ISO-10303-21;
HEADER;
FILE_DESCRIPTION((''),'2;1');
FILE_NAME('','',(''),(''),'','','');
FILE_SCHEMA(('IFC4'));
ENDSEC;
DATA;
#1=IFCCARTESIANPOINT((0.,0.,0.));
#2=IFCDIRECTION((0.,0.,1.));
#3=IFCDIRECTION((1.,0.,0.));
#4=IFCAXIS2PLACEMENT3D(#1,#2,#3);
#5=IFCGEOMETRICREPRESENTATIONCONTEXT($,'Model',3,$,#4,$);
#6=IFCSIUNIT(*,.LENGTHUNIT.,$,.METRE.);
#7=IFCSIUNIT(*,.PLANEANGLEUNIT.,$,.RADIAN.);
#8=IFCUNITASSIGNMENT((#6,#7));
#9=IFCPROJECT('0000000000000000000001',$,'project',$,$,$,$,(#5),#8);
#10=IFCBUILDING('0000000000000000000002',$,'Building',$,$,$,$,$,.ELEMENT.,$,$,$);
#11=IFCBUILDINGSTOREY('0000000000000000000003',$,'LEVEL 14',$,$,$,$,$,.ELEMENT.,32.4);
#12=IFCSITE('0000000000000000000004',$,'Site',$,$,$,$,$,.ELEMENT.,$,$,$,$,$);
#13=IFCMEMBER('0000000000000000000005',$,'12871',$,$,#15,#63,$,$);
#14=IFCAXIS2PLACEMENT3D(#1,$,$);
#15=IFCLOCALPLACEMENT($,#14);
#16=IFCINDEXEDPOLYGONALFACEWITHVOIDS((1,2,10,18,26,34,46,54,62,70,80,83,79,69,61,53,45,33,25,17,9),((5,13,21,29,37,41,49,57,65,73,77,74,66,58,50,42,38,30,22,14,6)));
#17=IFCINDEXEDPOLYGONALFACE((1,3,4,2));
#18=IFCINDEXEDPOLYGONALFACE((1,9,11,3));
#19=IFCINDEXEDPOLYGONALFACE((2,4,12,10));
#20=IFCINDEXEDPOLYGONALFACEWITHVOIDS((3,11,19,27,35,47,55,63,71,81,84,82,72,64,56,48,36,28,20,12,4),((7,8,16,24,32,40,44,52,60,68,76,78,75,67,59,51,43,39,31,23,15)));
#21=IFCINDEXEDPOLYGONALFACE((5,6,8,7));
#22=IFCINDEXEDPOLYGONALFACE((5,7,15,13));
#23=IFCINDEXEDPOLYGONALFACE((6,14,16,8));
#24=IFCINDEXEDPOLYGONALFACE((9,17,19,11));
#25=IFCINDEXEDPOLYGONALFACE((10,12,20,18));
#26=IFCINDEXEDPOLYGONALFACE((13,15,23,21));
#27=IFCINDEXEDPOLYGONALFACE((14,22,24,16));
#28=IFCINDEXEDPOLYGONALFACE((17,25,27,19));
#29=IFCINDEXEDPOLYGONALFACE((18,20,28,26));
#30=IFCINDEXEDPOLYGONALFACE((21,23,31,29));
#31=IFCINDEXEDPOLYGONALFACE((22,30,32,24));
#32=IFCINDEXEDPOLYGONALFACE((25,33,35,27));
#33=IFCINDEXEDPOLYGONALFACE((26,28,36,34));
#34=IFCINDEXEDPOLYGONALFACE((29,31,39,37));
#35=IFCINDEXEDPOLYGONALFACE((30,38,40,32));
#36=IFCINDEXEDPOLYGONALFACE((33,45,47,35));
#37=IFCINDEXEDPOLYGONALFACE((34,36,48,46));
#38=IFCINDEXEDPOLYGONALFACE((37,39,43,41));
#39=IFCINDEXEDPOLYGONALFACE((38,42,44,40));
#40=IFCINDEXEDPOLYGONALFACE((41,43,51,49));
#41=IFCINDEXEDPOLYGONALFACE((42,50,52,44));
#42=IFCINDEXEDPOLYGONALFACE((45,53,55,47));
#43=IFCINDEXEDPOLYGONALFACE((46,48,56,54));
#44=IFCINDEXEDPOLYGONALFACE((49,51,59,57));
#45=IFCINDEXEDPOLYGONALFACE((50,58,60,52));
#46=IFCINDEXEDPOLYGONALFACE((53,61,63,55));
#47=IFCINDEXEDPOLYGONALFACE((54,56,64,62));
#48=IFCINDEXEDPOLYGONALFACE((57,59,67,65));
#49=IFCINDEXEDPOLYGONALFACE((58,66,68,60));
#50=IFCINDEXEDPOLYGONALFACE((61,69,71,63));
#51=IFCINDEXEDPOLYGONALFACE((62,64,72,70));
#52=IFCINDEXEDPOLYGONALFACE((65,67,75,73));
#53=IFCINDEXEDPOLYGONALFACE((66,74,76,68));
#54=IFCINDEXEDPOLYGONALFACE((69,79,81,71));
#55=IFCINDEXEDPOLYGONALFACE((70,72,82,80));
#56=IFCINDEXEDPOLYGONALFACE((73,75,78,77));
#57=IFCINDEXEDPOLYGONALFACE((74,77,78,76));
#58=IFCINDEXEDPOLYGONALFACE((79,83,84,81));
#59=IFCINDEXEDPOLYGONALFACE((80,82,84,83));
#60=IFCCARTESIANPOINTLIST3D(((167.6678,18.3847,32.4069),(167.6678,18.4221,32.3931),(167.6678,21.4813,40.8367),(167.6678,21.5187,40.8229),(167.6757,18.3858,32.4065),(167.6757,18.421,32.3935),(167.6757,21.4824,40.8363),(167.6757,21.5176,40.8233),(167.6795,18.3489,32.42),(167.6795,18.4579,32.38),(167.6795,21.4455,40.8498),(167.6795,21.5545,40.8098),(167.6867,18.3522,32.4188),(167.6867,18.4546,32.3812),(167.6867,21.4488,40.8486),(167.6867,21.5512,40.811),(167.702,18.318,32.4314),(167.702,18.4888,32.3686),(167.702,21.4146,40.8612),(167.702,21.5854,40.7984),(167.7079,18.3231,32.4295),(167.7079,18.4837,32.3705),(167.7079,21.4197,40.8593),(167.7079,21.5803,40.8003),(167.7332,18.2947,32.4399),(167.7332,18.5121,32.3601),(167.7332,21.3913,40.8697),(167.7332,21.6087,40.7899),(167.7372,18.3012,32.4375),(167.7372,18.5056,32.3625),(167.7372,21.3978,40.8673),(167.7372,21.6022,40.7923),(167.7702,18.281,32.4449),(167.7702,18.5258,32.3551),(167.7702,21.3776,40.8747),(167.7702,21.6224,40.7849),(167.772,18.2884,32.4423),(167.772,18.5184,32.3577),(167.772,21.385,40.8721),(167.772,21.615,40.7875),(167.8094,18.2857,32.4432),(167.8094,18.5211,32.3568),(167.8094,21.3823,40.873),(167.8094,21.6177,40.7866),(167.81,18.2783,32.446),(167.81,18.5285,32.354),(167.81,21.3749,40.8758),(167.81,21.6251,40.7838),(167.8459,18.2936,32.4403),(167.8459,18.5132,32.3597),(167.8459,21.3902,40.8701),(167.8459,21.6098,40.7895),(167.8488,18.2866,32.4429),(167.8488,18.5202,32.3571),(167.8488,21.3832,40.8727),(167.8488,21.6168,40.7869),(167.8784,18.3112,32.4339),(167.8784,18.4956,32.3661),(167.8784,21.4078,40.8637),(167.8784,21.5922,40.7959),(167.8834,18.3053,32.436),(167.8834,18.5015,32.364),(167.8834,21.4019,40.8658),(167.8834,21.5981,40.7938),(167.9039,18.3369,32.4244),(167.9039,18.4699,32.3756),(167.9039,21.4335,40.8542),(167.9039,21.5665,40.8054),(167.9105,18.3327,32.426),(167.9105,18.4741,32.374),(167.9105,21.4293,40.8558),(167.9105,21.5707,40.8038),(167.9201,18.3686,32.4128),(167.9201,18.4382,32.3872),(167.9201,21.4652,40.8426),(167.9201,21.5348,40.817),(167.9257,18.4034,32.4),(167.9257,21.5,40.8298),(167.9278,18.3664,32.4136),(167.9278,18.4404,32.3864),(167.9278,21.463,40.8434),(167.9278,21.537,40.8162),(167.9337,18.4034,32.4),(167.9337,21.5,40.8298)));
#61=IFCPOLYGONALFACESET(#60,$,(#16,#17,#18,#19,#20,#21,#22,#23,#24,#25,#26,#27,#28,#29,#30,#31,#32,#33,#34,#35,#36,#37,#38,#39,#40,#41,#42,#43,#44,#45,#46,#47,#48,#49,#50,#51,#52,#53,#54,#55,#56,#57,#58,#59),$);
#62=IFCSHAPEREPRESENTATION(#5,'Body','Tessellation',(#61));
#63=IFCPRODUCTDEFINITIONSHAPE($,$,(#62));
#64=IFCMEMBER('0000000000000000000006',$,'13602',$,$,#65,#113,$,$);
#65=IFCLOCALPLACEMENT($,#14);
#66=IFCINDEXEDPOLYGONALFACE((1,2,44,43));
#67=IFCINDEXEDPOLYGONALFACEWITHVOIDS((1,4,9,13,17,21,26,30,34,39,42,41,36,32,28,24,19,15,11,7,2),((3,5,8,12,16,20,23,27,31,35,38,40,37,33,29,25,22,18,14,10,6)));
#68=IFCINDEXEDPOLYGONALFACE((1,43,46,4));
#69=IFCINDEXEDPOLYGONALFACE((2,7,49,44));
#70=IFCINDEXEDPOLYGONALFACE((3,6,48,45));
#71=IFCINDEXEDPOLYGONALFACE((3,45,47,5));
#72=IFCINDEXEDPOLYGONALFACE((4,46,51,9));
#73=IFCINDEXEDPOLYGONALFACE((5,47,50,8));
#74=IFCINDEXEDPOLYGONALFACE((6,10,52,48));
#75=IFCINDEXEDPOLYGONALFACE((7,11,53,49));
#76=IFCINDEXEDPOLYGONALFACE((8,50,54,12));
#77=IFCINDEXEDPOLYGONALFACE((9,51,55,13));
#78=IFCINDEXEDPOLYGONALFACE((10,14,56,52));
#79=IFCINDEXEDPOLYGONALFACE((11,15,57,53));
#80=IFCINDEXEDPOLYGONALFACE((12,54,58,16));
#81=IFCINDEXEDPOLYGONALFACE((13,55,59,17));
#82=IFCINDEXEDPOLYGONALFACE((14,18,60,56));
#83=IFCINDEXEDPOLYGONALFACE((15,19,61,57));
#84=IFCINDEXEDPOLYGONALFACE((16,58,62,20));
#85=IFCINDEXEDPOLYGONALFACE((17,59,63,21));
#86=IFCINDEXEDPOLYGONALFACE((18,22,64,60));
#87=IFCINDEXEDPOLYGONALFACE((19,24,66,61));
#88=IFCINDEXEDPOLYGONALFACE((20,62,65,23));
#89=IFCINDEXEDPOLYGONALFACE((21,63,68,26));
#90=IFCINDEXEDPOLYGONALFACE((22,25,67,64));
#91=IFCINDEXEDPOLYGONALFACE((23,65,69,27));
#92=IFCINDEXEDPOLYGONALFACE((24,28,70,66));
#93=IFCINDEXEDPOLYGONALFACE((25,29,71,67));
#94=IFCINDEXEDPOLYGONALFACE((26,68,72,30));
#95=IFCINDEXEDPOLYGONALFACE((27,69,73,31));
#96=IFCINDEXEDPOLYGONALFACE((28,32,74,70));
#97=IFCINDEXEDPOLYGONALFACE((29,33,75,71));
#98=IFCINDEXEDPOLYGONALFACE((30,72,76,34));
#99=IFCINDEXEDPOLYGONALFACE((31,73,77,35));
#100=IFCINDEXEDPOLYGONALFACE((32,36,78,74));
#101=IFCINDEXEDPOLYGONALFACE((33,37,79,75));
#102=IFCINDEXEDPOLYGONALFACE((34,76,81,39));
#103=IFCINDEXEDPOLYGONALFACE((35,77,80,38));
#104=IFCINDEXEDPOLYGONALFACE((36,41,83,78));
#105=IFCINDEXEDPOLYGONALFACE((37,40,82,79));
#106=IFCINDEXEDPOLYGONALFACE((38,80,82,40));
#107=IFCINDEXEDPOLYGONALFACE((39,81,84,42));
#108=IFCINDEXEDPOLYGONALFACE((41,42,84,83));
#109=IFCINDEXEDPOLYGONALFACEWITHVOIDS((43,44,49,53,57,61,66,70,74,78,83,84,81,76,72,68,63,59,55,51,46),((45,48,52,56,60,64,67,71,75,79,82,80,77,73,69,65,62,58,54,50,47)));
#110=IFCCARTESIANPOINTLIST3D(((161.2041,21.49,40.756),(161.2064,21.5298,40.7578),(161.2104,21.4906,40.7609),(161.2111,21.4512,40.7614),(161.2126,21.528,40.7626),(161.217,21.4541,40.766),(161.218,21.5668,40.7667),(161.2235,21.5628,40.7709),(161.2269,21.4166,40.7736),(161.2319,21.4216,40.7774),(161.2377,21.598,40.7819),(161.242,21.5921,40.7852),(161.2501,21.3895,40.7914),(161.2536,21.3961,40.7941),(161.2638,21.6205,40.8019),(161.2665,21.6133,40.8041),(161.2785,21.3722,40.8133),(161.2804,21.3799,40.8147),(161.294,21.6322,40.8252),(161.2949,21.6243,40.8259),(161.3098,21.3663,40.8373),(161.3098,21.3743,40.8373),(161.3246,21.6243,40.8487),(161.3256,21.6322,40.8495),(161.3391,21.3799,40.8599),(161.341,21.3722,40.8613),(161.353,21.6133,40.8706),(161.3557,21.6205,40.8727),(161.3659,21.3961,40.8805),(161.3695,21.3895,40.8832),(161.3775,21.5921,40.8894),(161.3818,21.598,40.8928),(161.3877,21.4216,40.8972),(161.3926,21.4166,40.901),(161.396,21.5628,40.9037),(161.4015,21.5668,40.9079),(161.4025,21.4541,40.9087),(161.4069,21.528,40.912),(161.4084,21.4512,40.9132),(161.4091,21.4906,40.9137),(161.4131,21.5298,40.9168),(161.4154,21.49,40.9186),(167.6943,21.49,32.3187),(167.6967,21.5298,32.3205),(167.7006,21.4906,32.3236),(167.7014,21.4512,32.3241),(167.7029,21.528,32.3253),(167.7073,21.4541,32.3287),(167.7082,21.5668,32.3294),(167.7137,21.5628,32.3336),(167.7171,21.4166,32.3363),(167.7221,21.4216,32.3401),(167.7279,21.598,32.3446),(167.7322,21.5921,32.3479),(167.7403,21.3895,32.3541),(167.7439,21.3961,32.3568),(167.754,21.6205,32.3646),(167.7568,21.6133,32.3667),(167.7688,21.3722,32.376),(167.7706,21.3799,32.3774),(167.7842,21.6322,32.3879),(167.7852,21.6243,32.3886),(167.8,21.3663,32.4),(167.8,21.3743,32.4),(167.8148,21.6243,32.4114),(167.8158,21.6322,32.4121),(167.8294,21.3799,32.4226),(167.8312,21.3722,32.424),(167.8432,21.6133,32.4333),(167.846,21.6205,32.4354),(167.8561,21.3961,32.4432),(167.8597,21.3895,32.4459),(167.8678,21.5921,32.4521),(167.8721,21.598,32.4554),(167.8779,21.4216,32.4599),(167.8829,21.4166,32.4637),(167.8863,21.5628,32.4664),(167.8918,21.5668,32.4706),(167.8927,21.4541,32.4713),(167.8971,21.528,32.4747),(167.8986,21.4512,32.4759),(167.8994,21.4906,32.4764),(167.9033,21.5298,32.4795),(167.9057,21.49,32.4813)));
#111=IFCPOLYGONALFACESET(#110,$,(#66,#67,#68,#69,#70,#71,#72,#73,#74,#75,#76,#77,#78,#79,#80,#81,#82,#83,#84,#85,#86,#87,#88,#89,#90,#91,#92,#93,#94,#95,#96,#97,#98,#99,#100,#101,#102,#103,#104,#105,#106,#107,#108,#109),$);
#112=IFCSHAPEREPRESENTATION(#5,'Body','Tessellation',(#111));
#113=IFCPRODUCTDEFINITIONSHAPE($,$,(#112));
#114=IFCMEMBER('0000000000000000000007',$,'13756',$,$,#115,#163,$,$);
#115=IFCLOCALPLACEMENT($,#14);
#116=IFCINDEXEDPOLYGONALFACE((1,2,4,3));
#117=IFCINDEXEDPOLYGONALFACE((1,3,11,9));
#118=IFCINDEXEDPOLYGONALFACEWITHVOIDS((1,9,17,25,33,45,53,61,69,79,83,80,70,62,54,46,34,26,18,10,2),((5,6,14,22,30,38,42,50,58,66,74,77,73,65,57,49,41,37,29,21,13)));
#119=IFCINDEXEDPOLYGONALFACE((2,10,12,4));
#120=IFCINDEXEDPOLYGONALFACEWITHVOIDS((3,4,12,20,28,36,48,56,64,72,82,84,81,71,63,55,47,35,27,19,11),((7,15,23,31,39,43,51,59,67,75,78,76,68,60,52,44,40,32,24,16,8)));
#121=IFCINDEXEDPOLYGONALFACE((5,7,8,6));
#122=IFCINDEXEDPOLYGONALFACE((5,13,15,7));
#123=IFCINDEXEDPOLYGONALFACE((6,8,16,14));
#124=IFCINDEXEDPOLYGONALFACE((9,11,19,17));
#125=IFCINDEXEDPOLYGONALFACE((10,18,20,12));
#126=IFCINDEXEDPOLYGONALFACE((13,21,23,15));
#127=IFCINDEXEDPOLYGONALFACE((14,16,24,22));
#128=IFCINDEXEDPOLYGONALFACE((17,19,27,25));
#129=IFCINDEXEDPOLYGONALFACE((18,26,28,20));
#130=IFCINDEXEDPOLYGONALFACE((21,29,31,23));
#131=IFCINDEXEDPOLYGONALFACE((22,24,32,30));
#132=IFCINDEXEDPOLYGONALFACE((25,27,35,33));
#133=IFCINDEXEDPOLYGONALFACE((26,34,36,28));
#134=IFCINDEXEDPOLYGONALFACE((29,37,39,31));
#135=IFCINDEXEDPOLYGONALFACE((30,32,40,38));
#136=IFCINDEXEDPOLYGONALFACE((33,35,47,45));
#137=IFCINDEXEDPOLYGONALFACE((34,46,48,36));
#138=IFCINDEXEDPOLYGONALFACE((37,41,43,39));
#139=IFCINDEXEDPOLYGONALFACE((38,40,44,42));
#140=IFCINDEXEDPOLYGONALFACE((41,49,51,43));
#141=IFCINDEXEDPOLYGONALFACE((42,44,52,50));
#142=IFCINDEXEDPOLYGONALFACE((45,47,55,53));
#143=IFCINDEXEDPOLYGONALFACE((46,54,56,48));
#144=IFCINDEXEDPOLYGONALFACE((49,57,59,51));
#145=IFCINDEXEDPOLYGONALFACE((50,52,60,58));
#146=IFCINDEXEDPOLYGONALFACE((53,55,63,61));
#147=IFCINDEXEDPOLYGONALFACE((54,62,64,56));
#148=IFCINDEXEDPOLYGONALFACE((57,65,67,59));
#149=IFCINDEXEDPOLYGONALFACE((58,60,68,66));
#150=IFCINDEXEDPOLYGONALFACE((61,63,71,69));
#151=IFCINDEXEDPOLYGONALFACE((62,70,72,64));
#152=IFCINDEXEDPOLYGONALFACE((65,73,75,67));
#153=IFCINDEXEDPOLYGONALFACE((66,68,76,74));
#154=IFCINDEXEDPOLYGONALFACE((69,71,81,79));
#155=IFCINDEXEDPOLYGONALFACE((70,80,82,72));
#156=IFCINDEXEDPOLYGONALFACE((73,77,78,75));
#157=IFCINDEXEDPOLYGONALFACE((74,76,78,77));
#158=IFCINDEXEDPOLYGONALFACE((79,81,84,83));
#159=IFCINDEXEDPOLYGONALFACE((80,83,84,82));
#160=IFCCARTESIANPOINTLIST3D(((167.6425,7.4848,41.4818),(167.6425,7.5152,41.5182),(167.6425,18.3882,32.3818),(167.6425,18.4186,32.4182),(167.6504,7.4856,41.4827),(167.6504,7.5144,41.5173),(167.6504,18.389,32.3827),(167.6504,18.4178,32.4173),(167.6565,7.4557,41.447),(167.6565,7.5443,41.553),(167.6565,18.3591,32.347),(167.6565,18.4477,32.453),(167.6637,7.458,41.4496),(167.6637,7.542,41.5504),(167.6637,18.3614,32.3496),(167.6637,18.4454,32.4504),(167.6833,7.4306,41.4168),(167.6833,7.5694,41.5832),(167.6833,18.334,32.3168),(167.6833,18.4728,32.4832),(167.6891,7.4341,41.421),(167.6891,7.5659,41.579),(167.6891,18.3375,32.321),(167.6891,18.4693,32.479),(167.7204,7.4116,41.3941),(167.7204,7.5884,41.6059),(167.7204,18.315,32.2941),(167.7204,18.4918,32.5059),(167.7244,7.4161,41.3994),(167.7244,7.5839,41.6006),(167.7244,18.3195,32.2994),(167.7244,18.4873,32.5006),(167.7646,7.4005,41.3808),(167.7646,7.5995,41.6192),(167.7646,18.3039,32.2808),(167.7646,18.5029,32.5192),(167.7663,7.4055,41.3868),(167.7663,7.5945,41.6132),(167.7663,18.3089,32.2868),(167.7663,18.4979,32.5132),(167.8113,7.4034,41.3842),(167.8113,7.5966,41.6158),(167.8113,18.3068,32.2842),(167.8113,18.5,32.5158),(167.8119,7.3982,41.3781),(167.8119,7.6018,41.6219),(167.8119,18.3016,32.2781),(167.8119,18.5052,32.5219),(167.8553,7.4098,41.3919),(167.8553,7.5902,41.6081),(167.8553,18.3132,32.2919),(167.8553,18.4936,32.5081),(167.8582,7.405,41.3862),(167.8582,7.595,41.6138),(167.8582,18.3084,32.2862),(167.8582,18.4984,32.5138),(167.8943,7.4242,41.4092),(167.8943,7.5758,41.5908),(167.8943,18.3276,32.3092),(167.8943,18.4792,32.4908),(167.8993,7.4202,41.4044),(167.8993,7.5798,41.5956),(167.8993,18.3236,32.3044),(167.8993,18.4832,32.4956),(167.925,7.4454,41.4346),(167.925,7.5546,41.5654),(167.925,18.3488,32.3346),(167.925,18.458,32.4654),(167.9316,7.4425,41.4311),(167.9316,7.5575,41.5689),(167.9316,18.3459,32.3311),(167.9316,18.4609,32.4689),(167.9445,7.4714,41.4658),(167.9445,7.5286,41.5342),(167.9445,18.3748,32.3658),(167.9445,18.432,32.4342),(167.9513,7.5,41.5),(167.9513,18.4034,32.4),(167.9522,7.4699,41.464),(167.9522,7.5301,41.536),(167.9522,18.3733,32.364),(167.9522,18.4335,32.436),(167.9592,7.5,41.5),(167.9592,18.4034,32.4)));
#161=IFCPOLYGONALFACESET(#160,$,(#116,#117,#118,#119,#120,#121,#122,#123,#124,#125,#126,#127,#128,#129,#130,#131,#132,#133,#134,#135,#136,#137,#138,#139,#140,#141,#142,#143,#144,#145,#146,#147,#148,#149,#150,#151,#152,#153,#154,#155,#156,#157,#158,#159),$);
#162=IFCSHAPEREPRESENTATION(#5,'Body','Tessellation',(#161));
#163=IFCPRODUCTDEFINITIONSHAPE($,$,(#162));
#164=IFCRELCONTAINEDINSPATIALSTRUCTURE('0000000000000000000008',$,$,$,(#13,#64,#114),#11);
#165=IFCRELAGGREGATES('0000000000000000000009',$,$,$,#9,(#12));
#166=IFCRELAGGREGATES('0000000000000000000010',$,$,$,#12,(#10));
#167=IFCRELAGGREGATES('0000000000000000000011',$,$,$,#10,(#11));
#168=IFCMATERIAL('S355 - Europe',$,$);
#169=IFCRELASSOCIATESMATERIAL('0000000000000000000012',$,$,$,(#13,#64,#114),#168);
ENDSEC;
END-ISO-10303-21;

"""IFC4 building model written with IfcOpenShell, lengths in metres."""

from ifc_helpers import new_model, si_unit, frame, origin_with_axes, origin_2d_with_axis, place, context, project, spatial, hollow_circle, extrude, material, material_profile, profile_set, profile_usage, element, save


model = new_model("IFC4")

# Units and contexts
model_context = context("Model", 3, world=origin_with_axes())
ifc_project = project(units=[si_unit("LENGTHUNIT", "METRE"), si_unit("PLANEANGLEUNIT", "RADIAN")], contexts=[model_context])

# Site, building, storey
site = spatial("IfcSite", under=ifc_project, Name="Site", CompositionType="ELEMENT")
building = spatial("IfcBuilding", under=site, Name="Building", CompositionType="ELEMENT")
storey = spatial("IfcBuildingStorey", under=building, Name="LEVEL 14", CompositionType="ELEMENT", Elevation=32.4)

# Shared definitions
ifc_material = material(Name="S355 - Europe")

# Members
ifc_material_profile_1 = material_profile(ifc_material, hollow_circle(Radius=0.1337, WallThickness=0.008, at=origin_2d_with_axis()))
ifc_profile_set_1 = profile_set([ifc_material_profile_1])
ifc_profile_usage_1 = profile_usage(ifc_profile_set_1, cardinal=10)
member_1_placement = place(None, frame((167.8, 21.5, 40.8298), z_axis=(0.0, -0.344811, -0.938672), x_axis=(1.0, 0.0, 0.0)))
element("IfcMember", 1, at=member_1_placement, inside=storey, material=ifc_profile_usage_1, Name="12871", context=model_context, shape_type="SweptSolid", body=[
    extrude(hollow_circle(Radius=0.1337, WallThickness=0.008, at=origin_2d_with_axis()), origin_with_axes(), (0.0, 0.0, 1.0), 8.9806),
])
ifc_material_profile_2 = material_profile(ifc_material, hollow_circle(Radius=0.1337, WallThickness=0.008, at=origin_2d_with_axis()))
ifc_profile_set_2 = profile_set([ifc_material_profile_2])
ifc_profile_usage_2 = profile_usage(ifc_profile_set_2, cardinal=10)
member_2_placement = place(None, frame((167.8, 21.5, 32.4), z_axis=(-0.609711, 0.0, 0.792624), x_axis=(0.0, -1.0, 0.0)))
element("IfcMember", 2, at=member_2_placement, inside=storey, material=ifc_profile_usage_2, Name="13602", context=model_context, shape_type="SweptSolid", body=[
    extrude(hollow_circle(Radius=0.1337, WallThickness=0.008, at=origin_2d_with_axis()), origin_with_axes(), (0.0, 0.0, 1.0), 10.6448),
])
ifc_material_profile_3 = material_profile(ifc_material, hollow_circle(Radius=0.1593, WallThickness=0.008, at=origin_2d_with_axis()))
ifc_profile_set_3 = profile_set([ifc_material_profile_3])
ifc_profile_usage_3 = profile_usage(ifc_profile_set_3, cardinal=10)
member_3_placement = place(None, frame((167.8, 18.4034, 32.4), z_axis=(0.0, -0.767742, 0.640759), x_axis=(1.0, 0.0, 0.0)))
element("IfcMember", 3, at=member_3_placement, inside=storey, material=ifc_profile_usage_3, Name="13756", context=model_context, shape_type="SweptSolid", body=[
    extrude(hollow_circle(Radius=0.1593, WallThickness=0.008, at=origin_2d_with_axis()), origin_with_axes(), (0.0, 0.0, 1.0), 14.2019),
])

save(model, "model.ifc")
